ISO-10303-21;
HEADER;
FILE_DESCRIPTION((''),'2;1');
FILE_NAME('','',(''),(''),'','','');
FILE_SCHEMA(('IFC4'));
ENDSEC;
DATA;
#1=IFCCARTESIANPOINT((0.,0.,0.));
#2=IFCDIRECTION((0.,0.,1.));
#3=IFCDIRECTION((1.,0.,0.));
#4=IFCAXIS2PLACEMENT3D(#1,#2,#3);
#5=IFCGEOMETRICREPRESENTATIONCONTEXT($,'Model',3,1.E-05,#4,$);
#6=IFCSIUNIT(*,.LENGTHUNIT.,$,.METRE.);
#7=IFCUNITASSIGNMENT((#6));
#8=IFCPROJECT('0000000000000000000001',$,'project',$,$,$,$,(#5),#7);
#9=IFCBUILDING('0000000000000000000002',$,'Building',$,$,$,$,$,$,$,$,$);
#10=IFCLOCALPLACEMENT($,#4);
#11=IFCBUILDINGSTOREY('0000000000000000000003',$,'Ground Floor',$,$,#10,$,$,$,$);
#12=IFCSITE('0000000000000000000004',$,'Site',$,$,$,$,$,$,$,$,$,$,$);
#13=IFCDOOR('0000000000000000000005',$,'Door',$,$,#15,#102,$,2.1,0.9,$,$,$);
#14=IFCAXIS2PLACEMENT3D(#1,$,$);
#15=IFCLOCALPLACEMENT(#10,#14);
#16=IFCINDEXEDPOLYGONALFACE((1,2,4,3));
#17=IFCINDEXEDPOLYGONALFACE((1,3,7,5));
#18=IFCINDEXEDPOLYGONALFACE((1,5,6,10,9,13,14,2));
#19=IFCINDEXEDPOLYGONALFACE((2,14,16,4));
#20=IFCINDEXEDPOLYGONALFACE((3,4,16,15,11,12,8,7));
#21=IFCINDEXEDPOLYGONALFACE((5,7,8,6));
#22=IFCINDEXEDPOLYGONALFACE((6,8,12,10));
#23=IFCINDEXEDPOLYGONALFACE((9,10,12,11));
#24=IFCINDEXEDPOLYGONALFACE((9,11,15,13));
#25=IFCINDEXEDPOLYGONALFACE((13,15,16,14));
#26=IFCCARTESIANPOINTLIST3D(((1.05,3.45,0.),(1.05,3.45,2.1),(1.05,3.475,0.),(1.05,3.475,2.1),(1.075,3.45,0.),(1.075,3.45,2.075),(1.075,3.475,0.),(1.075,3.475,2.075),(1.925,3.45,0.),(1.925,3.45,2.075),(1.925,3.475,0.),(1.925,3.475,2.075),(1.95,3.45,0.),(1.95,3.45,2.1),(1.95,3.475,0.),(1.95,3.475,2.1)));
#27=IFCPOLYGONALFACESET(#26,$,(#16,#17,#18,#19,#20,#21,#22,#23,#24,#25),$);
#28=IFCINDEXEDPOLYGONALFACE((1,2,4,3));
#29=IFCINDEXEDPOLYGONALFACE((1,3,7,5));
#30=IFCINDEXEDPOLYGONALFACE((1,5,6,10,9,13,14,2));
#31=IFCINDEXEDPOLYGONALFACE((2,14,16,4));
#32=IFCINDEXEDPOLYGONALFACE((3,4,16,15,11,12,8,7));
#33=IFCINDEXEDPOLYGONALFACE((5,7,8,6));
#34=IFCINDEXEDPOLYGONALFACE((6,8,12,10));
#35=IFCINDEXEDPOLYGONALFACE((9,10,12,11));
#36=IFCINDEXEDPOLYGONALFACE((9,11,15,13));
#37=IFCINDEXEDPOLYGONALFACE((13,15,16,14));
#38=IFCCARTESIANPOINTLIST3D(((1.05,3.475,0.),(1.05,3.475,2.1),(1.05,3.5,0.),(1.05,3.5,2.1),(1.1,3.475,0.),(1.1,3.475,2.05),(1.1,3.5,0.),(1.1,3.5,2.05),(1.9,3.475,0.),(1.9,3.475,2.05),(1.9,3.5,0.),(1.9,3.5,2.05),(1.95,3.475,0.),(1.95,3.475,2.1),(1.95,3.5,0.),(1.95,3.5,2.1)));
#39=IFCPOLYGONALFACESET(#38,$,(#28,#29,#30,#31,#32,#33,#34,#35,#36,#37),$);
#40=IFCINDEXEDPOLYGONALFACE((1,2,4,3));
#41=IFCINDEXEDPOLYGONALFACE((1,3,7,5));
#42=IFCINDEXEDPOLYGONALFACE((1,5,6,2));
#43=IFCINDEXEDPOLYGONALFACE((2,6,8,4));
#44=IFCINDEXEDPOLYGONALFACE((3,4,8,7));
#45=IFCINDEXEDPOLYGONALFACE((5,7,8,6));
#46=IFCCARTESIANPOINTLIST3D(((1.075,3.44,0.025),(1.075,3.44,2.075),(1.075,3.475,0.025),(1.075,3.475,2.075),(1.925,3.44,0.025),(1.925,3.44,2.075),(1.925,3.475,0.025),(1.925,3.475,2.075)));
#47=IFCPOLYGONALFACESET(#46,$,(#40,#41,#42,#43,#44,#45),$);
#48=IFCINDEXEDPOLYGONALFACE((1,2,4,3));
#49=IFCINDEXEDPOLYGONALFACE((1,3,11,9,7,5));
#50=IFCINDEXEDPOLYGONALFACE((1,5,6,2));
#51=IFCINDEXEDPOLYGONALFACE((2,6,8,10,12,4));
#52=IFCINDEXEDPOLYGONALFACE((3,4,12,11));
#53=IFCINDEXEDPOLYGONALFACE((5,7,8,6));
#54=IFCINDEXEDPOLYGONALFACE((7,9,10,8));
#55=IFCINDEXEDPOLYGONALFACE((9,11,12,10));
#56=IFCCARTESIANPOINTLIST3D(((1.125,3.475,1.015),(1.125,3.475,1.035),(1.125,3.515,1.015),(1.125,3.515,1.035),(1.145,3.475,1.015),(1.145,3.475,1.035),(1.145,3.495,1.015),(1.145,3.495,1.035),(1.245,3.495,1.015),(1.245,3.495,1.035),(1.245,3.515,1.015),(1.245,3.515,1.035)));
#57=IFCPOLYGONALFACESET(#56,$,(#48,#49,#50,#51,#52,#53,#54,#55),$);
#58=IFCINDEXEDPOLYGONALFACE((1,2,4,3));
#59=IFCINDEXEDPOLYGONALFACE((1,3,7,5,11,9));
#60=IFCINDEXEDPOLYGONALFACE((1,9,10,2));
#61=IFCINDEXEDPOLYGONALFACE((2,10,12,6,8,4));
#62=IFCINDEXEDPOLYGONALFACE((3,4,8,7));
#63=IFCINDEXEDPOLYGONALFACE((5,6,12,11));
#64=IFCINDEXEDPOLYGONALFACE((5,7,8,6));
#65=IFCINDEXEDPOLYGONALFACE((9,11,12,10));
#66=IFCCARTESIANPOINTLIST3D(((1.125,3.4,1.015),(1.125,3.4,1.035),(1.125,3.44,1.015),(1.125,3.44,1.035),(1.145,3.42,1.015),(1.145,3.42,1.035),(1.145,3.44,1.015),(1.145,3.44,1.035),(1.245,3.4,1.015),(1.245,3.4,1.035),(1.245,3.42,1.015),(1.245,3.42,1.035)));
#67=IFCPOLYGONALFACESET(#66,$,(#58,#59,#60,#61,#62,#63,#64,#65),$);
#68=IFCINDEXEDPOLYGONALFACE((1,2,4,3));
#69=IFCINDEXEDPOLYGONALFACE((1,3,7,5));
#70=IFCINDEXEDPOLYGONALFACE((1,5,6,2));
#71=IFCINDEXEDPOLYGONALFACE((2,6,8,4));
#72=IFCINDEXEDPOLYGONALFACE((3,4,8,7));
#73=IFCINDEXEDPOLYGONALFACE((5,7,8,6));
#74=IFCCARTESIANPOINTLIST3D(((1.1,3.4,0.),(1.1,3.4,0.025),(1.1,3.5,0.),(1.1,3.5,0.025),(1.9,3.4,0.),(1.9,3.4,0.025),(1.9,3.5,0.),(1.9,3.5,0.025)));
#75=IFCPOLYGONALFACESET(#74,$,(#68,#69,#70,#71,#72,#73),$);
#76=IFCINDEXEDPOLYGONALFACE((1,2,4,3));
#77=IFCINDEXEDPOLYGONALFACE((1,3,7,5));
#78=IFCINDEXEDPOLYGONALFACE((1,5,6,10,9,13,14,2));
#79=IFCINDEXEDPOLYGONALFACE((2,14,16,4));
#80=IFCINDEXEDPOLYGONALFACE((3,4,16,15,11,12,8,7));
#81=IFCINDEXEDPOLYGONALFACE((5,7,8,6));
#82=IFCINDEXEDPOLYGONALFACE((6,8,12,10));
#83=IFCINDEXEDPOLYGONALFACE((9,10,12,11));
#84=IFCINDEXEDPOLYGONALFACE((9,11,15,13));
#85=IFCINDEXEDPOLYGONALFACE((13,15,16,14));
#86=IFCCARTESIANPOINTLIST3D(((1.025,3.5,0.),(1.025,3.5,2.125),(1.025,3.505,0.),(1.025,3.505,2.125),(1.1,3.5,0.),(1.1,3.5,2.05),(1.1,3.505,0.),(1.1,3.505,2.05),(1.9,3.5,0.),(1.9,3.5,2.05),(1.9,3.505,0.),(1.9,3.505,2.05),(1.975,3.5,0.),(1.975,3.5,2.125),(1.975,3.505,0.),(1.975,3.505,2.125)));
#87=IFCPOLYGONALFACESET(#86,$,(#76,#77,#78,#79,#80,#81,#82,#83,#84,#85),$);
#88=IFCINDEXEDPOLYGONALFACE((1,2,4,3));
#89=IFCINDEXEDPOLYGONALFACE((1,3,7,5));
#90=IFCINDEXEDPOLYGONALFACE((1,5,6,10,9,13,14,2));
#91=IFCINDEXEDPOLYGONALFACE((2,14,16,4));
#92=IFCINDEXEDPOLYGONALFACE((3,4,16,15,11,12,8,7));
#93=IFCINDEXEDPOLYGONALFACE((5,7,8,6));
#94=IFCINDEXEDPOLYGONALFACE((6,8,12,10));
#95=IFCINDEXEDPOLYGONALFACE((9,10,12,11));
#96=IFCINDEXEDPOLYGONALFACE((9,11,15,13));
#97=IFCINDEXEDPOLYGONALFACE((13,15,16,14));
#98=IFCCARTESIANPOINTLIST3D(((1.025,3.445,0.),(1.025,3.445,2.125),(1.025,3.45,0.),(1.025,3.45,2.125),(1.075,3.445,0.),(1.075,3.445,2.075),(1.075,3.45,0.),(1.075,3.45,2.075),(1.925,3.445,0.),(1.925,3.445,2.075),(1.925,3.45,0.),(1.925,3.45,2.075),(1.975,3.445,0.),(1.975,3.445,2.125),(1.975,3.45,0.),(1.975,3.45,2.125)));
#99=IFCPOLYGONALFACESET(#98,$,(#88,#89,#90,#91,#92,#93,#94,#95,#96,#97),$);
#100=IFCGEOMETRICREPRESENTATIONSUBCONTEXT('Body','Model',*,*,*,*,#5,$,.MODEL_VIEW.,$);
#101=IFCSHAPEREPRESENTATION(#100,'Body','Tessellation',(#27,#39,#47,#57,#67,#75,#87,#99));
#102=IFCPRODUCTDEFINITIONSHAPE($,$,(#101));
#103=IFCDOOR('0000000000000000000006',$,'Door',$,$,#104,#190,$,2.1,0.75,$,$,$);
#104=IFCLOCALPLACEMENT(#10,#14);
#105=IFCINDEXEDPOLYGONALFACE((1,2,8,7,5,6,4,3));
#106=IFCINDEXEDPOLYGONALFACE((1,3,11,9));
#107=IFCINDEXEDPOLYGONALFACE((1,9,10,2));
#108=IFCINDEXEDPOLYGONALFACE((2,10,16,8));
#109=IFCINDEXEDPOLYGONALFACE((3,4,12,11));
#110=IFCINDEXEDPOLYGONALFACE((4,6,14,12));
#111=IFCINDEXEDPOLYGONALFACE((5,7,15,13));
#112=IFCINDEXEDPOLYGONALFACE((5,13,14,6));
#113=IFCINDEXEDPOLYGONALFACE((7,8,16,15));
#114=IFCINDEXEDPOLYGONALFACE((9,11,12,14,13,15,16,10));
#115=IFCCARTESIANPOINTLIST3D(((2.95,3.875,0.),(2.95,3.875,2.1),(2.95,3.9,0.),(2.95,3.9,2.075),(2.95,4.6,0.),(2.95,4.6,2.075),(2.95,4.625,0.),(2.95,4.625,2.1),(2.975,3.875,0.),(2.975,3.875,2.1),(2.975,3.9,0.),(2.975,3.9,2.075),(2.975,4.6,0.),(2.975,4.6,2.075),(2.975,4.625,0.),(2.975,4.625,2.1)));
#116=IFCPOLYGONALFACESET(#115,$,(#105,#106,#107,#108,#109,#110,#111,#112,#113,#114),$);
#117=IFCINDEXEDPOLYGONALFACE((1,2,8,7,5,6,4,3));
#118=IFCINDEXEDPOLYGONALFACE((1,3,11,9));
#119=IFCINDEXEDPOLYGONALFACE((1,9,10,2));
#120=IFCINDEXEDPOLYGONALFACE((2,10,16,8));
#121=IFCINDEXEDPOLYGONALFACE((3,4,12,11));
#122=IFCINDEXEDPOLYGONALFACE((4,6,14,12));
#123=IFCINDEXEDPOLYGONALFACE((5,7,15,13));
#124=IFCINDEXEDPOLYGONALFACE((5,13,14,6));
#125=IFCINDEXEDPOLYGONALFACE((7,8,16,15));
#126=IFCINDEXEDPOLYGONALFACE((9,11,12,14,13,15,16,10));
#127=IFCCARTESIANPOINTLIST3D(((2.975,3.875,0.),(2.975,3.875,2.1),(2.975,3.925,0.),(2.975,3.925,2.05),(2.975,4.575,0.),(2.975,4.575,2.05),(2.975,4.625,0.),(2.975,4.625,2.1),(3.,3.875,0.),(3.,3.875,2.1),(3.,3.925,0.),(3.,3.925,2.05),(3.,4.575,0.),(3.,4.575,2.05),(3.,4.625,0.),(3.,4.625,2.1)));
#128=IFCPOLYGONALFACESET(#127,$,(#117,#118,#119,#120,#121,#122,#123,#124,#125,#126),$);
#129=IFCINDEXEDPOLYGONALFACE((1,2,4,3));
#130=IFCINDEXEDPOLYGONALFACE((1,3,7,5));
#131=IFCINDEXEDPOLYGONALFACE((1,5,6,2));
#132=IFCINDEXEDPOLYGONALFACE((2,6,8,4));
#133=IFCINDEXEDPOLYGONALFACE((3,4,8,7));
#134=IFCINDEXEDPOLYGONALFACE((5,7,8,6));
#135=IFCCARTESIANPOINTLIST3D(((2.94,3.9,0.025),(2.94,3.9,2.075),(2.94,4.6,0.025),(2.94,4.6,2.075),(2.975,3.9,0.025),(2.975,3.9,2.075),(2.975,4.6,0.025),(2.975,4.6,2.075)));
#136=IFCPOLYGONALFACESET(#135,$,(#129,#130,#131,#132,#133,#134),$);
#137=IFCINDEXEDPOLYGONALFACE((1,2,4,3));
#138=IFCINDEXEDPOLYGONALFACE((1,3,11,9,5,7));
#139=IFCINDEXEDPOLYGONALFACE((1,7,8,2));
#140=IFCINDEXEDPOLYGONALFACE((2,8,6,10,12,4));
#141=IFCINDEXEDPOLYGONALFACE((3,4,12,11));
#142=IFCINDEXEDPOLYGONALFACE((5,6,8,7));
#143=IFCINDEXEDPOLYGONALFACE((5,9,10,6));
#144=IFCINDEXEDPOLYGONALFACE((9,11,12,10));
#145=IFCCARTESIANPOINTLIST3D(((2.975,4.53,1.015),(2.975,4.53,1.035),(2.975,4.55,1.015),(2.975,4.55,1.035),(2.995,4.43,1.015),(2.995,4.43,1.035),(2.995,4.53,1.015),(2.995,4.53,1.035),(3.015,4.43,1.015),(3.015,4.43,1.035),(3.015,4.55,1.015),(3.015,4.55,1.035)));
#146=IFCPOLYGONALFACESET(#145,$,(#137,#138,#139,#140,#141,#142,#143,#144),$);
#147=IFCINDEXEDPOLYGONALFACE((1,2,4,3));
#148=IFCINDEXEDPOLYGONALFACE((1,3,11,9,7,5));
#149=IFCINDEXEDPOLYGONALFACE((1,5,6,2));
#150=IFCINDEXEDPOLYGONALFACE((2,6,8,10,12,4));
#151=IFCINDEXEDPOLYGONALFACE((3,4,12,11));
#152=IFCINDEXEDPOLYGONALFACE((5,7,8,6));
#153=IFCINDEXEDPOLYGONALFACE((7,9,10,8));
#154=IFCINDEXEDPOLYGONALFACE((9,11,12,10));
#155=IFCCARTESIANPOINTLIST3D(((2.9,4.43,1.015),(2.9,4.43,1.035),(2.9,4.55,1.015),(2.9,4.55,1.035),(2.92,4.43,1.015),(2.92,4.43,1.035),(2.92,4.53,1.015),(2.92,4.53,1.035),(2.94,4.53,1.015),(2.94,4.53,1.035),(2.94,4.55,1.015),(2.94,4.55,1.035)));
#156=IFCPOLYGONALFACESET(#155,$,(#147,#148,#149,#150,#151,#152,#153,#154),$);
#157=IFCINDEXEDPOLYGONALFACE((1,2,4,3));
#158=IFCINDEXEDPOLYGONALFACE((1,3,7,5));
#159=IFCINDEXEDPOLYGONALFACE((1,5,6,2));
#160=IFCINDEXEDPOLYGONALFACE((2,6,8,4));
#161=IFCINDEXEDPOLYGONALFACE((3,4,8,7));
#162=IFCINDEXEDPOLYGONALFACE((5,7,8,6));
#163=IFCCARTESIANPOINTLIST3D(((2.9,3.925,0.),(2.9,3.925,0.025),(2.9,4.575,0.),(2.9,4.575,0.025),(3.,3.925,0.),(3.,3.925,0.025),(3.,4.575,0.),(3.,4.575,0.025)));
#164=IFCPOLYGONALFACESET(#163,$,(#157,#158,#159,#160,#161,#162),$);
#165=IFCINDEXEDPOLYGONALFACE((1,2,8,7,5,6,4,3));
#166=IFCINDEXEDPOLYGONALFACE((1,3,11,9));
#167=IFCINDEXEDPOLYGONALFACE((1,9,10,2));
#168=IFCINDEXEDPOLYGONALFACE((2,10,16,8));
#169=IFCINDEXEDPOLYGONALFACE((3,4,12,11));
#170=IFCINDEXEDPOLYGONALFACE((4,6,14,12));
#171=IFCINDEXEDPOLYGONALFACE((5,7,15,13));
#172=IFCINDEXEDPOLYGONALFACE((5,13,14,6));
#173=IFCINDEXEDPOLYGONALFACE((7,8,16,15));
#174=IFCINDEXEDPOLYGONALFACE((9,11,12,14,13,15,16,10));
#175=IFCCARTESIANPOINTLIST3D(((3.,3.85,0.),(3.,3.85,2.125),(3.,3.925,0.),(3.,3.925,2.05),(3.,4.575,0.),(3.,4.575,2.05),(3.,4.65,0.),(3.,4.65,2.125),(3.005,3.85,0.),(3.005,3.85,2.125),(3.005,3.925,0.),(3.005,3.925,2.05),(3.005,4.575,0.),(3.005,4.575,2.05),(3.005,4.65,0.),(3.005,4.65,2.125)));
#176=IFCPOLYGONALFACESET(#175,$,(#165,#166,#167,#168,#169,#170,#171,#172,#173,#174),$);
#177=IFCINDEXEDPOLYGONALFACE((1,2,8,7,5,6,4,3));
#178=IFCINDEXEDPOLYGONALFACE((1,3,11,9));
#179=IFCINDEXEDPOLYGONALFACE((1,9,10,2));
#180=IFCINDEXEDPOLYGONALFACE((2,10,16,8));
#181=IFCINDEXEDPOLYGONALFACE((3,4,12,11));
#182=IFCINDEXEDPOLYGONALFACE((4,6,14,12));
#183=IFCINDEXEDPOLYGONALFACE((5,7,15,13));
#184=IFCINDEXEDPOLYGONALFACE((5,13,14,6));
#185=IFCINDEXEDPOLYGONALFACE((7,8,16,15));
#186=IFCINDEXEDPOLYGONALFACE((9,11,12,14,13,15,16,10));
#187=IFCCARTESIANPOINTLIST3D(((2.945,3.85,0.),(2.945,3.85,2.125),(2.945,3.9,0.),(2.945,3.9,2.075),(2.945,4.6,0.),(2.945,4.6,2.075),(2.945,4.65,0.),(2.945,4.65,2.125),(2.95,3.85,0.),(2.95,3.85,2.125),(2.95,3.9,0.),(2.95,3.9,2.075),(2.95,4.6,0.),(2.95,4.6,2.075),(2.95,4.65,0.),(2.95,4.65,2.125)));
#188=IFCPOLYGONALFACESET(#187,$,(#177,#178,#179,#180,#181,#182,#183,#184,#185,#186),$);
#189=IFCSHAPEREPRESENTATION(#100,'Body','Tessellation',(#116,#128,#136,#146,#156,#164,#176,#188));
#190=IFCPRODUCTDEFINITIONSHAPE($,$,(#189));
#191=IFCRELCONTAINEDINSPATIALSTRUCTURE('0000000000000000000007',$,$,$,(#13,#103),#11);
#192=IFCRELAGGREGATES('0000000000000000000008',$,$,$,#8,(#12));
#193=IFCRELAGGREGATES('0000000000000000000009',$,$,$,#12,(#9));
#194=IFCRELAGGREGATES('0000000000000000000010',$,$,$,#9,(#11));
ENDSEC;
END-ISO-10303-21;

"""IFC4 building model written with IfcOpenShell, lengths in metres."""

from ifc_helpers import new_model, si_unit, frame, origin_with_axes, place, context, subcontext, project, spatial, line, indexed_curve, outline, extrude, element, save


model = new_model("IFC4")

# Units and contexts
model_context = context("Model", 3, precision=1e-05, world=origin_with_axes())
body_context = subcontext(model_context, "Body", "Model", "MODEL_VIEW")
ifc_project = project(units=[si_unit("LENGTHUNIT", "METRE")], contexts=[model_context])

# Site, building, storey
site = spatial("IfcSite", under=ifc_project, Name="Site")
building = spatial("IfcBuilding", under=site, Name="Building")
storey_placement = place(None, origin_with_axes())
storey = spatial("IfcBuildingStorey", under=building, at=storey_placement, Name="Ground Floor")

# Doors
door_1_placement = place(storey_placement, frame((1.95, 3.5, 0.0), z_axis=(0.0, 0.0, 1.0), x_axis=(-1.0, 0.0, 0.0)))
element("IfcDoor", 1, at=door_1_placement, inside=storey, Name="Door", OverallHeight=2.1, OverallWidth=0.9, context=body_context, shape_type="SweptSolid", body=[
    extrude(outline(indexed_curve([(0.0, 0.0), (0.0, 2.1), (0.9, 2.1), (0.9, 0.0), (0.875, 0.0), (0.875, 2.075), (0.025, 2.075), (0.025, 0.0)], segments=[line(1, 2, 3, 4, 5, 6, 7, 8, 1)])), frame((0.0, 0.025, 0.0), z_axis=(0.0, -1.0, 0.0), x_axis=(1.0, 0.0, 0.0)), (0.0, 0.0, -1.0), 0.025),
    extrude(outline(indexed_curve([(0.0, 0.0), (0.0, 2.1), (0.9, 2.1), (0.9, 0.0), (0.85, 0.0), (0.85, 2.05), (0.05, 2.05), (0.05, 0.0)], segments=[line(1, 2, 3, 4, 5, 6, 7, 8, 1)])), frame((0.0, 0.0, 0.0), z_axis=(0.0, -1.0, 0.0), x_axis=(1.0, 0.0, 0.0)), (0.0, 0.0, -1.0), 0.025),
    extrude(outline(indexed_curve([(0.0, 0.0), (0.85, 0.0), (0.85, 0.035), (0.0, 0.035)], segments=[line(1, 2, 3, 4, 1)])), frame((0.025, 0.025, 0.025), z_axis=(0.0, 0.0, 1.0), x_axis=(1.0, 0.0, 0.0)), (0.0, 0.0, 1.0), 2.05),
    extrude(outline(indexed_curve([(0.0, 0.0), (0.0, -0.04), (-0.12, -0.04), (-0.12, -0.02), (-0.02, -0.02), (-0.02, 0.0)], segments=[line(1, 2, 3, 4, 5, 6, 1)])), frame((0.825, 0.025, 1.015), z_axis=(0.0, 0.0, 1.0), x_axis=(1.0, 0.0, 0.0)), (0.0, 0.0, 1.0), 0.02),
    extrude(outline(indexed_curve([(0.0, 0.0), (0.0, 0.04), (-0.12, 0.04), (-0.12, 0.02), (-0.02, 0.02), (-0.02, 0.0)], segments=[line(1, 2, 3, 4, 5, 6, 1)])), frame((0.825, 0.06, 1.015), z_axis=(0.0, 0.0, 1.0), x_axis=(1.0, 0.0, 0.0)), (0.0, 0.0, 1.0), 0.02),
    extrude(outline(indexed_curve([(0.0, 0.0), (0.8, 0.0), (0.8, 0.1), (0.0, 0.1)], segments=[line(1, 2, 3, 4, 1)])), frame((0.05, 0.0, 0.0), z_axis=(0.0, 0.0, 1.0), x_axis=(1.0, 0.0, 0.0)), (0.0, 0.0, 1.0), 0.025),
    extrude(outline(indexed_curve([(0.0, 0.0), (0.0, 2.125), (0.95, 2.125), (0.95, 0.0), (0.875, 0.0), (0.875, 2.05), (0.075, 2.05), (0.075, 0.0)], segments=[line(1, 2, 3, 4, 5, 6, 7, 8, 1)])), frame((-0.025, -0.005, 0.0), z_axis=(0.0, -1.0, 0.0), x_axis=(1.0, 0.0, 0.0)), (0.0, 0.0, -1.0), 0.005),
    extrude(outline(indexed_curve([(0.0, 0.0), (0.0, 2.125), (0.95, 2.125), (0.95, 0.0), (0.9, 0.0), (0.9, 2.075), (0.05, 2.075), (0.05, 0.0)], segments=[line(1, 2, 3, 4, 5, 6, 7, 8, 1)])), frame((-0.025, 0.05, 0.0), z_axis=(0.0, -1.0, 0.0), x_axis=(1.0, 0.0, 0.0)), (0.0, 0.0, -1.0), 0.005),
])
door_2_placement = place(storey_placement, frame((3.0, 3.875, 0.0), z_axis=(0.0, 0.0, 1.0), x_axis=(0.0, 1.0, 0.0)))
element("IfcDoor", 2, at=door_2_placement, inside=storey, Name="Door", OverallHeight=2.1, OverallWidth=0.75, context=body_context, shape_type="SweptSolid", body=[
    extrude(outline(indexed_curve([(0.0, 0.0), (0.0, 2.1), (0.75, 2.1), (0.75, 0.0), (0.725, 0.0), (0.725, 2.075), (0.025, 2.075), (0.025, 0.0)], segments=[line(1, 2, 3, 4, 5, 6, 7, 8, 1)])), frame((0.0, 0.025, 0.0), z_axis=(0.0, -1.0, 0.0), x_axis=(1.0, 0.0, 0.0)), (0.0, 0.0, -1.0), 0.025),
    extrude(outline(indexed_curve([(0.0, 0.0), (0.0, 2.1), (0.75, 2.1), (0.75, 0.0), (0.7, 0.0), (0.7, 2.05), (0.05, 2.05), (0.05, 0.0)], segments=[line(1, 2, 3, 4, 5, 6, 7, 8, 1)])), frame((0.0, 0.0, 0.0), z_axis=(0.0, -1.0, 0.0), x_axis=(1.0, 0.0, 0.0)), (0.0, 0.0, -1.0), 0.025),
    extrude(outline(indexed_curve([(0.0, 0.0), (0.7, 0.0), (0.7, 0.035), (0.0, 0.035)], segments=[line(1, 2, 3, 4, 1)])), frame((0.025, 0.025, 0.025), z_axis=(0.0, 0.0, 1.0), x_axis=(1.0, 0.0, 0.0)), (0.0, 0.0, 1.0), 2.05),
    extrude(outline(indexed_curve([(0.0, 0.0), (0.0, -0.04), (-0.12, -0.04), (-0.12, -0.02), (-0.02, -0.02), (-0.02, 0.0)], segments=[line(1, 2, 3, 4, 5, 6, 1)])), frame((0.675, 0.025, 1.015), z_axis=(0.0, 0.0, 1.0), x_axis=(1.0, 0.0, 0.0)), (0.0, 0.0, 1.0), 0.02),
    extrude(outline(indexed_curve([(0.0, 0.0), (0.0, 0.04), (-0.12, 0.04), (-0.12, 0.02), (-0.02, 0.02), (-0.02, 0.0)], segments=[line(1, 2, 3, 4, 5, 6, 1)])), frame((0.675, 0.06, 1.015), z_axis=(0.0, 0.0, 1.0), x_axis=(1.0, 0.0, 0.0)), (0.0, 0.0, 1.0), 0.02),
    extrude(outline(indexed_curve([(0.0, 0.0), (0.65, 0.0), (0.65, 0.1), (0.0, 0.1)], segments=[line(1, 2, 3, 4, 1)])), frame((0.05, 0.0, 0.0), z_axis=(0.0, 0.0, 1.0), x_axis=(1.0, 0.0, 0.0)), (0.0, 0.0, 1.0), 0.025),
    extrude(outline(indexed_curve([(0.0, 0.0), (0.0, 2.125), (0.8, 2.125), (0.8, 0.0), (0.725, 0.0), (0.725, 2.05), (0.075, 2.05), (0.075, 0.0)], segments=[line(1, 2, 3, 4, 5, 6, 7, 8, 1)])), frame((-0.025, -0.005, 0.0), z_axis=(0.0, -1.0, 0.0), x_axis=(1.0, 0.0, 0.0)), (0.0, 0.0, -1.0), 0.005),
    extrude(outline(indexed_curve([(0.0, 0.0), (0.0, 2.125), (0.8, 2.125), (0.8, 0.0), (0.75, 0.0), (0.75, 2.075), (0.05, 2.075), (0.05, 0.0)], segments=[line(1, 2, 3, 4, 5, 6, 7, 8, 1)])), frame((-0.025, 0.05, 0.0), z_axis=(0.0, -1.0, 0.0), x_axis=(1.0, 0.0, 0.0)), (0.0, 0.0, -1.0), 0.005),
])

save(model, "model.ifc")
